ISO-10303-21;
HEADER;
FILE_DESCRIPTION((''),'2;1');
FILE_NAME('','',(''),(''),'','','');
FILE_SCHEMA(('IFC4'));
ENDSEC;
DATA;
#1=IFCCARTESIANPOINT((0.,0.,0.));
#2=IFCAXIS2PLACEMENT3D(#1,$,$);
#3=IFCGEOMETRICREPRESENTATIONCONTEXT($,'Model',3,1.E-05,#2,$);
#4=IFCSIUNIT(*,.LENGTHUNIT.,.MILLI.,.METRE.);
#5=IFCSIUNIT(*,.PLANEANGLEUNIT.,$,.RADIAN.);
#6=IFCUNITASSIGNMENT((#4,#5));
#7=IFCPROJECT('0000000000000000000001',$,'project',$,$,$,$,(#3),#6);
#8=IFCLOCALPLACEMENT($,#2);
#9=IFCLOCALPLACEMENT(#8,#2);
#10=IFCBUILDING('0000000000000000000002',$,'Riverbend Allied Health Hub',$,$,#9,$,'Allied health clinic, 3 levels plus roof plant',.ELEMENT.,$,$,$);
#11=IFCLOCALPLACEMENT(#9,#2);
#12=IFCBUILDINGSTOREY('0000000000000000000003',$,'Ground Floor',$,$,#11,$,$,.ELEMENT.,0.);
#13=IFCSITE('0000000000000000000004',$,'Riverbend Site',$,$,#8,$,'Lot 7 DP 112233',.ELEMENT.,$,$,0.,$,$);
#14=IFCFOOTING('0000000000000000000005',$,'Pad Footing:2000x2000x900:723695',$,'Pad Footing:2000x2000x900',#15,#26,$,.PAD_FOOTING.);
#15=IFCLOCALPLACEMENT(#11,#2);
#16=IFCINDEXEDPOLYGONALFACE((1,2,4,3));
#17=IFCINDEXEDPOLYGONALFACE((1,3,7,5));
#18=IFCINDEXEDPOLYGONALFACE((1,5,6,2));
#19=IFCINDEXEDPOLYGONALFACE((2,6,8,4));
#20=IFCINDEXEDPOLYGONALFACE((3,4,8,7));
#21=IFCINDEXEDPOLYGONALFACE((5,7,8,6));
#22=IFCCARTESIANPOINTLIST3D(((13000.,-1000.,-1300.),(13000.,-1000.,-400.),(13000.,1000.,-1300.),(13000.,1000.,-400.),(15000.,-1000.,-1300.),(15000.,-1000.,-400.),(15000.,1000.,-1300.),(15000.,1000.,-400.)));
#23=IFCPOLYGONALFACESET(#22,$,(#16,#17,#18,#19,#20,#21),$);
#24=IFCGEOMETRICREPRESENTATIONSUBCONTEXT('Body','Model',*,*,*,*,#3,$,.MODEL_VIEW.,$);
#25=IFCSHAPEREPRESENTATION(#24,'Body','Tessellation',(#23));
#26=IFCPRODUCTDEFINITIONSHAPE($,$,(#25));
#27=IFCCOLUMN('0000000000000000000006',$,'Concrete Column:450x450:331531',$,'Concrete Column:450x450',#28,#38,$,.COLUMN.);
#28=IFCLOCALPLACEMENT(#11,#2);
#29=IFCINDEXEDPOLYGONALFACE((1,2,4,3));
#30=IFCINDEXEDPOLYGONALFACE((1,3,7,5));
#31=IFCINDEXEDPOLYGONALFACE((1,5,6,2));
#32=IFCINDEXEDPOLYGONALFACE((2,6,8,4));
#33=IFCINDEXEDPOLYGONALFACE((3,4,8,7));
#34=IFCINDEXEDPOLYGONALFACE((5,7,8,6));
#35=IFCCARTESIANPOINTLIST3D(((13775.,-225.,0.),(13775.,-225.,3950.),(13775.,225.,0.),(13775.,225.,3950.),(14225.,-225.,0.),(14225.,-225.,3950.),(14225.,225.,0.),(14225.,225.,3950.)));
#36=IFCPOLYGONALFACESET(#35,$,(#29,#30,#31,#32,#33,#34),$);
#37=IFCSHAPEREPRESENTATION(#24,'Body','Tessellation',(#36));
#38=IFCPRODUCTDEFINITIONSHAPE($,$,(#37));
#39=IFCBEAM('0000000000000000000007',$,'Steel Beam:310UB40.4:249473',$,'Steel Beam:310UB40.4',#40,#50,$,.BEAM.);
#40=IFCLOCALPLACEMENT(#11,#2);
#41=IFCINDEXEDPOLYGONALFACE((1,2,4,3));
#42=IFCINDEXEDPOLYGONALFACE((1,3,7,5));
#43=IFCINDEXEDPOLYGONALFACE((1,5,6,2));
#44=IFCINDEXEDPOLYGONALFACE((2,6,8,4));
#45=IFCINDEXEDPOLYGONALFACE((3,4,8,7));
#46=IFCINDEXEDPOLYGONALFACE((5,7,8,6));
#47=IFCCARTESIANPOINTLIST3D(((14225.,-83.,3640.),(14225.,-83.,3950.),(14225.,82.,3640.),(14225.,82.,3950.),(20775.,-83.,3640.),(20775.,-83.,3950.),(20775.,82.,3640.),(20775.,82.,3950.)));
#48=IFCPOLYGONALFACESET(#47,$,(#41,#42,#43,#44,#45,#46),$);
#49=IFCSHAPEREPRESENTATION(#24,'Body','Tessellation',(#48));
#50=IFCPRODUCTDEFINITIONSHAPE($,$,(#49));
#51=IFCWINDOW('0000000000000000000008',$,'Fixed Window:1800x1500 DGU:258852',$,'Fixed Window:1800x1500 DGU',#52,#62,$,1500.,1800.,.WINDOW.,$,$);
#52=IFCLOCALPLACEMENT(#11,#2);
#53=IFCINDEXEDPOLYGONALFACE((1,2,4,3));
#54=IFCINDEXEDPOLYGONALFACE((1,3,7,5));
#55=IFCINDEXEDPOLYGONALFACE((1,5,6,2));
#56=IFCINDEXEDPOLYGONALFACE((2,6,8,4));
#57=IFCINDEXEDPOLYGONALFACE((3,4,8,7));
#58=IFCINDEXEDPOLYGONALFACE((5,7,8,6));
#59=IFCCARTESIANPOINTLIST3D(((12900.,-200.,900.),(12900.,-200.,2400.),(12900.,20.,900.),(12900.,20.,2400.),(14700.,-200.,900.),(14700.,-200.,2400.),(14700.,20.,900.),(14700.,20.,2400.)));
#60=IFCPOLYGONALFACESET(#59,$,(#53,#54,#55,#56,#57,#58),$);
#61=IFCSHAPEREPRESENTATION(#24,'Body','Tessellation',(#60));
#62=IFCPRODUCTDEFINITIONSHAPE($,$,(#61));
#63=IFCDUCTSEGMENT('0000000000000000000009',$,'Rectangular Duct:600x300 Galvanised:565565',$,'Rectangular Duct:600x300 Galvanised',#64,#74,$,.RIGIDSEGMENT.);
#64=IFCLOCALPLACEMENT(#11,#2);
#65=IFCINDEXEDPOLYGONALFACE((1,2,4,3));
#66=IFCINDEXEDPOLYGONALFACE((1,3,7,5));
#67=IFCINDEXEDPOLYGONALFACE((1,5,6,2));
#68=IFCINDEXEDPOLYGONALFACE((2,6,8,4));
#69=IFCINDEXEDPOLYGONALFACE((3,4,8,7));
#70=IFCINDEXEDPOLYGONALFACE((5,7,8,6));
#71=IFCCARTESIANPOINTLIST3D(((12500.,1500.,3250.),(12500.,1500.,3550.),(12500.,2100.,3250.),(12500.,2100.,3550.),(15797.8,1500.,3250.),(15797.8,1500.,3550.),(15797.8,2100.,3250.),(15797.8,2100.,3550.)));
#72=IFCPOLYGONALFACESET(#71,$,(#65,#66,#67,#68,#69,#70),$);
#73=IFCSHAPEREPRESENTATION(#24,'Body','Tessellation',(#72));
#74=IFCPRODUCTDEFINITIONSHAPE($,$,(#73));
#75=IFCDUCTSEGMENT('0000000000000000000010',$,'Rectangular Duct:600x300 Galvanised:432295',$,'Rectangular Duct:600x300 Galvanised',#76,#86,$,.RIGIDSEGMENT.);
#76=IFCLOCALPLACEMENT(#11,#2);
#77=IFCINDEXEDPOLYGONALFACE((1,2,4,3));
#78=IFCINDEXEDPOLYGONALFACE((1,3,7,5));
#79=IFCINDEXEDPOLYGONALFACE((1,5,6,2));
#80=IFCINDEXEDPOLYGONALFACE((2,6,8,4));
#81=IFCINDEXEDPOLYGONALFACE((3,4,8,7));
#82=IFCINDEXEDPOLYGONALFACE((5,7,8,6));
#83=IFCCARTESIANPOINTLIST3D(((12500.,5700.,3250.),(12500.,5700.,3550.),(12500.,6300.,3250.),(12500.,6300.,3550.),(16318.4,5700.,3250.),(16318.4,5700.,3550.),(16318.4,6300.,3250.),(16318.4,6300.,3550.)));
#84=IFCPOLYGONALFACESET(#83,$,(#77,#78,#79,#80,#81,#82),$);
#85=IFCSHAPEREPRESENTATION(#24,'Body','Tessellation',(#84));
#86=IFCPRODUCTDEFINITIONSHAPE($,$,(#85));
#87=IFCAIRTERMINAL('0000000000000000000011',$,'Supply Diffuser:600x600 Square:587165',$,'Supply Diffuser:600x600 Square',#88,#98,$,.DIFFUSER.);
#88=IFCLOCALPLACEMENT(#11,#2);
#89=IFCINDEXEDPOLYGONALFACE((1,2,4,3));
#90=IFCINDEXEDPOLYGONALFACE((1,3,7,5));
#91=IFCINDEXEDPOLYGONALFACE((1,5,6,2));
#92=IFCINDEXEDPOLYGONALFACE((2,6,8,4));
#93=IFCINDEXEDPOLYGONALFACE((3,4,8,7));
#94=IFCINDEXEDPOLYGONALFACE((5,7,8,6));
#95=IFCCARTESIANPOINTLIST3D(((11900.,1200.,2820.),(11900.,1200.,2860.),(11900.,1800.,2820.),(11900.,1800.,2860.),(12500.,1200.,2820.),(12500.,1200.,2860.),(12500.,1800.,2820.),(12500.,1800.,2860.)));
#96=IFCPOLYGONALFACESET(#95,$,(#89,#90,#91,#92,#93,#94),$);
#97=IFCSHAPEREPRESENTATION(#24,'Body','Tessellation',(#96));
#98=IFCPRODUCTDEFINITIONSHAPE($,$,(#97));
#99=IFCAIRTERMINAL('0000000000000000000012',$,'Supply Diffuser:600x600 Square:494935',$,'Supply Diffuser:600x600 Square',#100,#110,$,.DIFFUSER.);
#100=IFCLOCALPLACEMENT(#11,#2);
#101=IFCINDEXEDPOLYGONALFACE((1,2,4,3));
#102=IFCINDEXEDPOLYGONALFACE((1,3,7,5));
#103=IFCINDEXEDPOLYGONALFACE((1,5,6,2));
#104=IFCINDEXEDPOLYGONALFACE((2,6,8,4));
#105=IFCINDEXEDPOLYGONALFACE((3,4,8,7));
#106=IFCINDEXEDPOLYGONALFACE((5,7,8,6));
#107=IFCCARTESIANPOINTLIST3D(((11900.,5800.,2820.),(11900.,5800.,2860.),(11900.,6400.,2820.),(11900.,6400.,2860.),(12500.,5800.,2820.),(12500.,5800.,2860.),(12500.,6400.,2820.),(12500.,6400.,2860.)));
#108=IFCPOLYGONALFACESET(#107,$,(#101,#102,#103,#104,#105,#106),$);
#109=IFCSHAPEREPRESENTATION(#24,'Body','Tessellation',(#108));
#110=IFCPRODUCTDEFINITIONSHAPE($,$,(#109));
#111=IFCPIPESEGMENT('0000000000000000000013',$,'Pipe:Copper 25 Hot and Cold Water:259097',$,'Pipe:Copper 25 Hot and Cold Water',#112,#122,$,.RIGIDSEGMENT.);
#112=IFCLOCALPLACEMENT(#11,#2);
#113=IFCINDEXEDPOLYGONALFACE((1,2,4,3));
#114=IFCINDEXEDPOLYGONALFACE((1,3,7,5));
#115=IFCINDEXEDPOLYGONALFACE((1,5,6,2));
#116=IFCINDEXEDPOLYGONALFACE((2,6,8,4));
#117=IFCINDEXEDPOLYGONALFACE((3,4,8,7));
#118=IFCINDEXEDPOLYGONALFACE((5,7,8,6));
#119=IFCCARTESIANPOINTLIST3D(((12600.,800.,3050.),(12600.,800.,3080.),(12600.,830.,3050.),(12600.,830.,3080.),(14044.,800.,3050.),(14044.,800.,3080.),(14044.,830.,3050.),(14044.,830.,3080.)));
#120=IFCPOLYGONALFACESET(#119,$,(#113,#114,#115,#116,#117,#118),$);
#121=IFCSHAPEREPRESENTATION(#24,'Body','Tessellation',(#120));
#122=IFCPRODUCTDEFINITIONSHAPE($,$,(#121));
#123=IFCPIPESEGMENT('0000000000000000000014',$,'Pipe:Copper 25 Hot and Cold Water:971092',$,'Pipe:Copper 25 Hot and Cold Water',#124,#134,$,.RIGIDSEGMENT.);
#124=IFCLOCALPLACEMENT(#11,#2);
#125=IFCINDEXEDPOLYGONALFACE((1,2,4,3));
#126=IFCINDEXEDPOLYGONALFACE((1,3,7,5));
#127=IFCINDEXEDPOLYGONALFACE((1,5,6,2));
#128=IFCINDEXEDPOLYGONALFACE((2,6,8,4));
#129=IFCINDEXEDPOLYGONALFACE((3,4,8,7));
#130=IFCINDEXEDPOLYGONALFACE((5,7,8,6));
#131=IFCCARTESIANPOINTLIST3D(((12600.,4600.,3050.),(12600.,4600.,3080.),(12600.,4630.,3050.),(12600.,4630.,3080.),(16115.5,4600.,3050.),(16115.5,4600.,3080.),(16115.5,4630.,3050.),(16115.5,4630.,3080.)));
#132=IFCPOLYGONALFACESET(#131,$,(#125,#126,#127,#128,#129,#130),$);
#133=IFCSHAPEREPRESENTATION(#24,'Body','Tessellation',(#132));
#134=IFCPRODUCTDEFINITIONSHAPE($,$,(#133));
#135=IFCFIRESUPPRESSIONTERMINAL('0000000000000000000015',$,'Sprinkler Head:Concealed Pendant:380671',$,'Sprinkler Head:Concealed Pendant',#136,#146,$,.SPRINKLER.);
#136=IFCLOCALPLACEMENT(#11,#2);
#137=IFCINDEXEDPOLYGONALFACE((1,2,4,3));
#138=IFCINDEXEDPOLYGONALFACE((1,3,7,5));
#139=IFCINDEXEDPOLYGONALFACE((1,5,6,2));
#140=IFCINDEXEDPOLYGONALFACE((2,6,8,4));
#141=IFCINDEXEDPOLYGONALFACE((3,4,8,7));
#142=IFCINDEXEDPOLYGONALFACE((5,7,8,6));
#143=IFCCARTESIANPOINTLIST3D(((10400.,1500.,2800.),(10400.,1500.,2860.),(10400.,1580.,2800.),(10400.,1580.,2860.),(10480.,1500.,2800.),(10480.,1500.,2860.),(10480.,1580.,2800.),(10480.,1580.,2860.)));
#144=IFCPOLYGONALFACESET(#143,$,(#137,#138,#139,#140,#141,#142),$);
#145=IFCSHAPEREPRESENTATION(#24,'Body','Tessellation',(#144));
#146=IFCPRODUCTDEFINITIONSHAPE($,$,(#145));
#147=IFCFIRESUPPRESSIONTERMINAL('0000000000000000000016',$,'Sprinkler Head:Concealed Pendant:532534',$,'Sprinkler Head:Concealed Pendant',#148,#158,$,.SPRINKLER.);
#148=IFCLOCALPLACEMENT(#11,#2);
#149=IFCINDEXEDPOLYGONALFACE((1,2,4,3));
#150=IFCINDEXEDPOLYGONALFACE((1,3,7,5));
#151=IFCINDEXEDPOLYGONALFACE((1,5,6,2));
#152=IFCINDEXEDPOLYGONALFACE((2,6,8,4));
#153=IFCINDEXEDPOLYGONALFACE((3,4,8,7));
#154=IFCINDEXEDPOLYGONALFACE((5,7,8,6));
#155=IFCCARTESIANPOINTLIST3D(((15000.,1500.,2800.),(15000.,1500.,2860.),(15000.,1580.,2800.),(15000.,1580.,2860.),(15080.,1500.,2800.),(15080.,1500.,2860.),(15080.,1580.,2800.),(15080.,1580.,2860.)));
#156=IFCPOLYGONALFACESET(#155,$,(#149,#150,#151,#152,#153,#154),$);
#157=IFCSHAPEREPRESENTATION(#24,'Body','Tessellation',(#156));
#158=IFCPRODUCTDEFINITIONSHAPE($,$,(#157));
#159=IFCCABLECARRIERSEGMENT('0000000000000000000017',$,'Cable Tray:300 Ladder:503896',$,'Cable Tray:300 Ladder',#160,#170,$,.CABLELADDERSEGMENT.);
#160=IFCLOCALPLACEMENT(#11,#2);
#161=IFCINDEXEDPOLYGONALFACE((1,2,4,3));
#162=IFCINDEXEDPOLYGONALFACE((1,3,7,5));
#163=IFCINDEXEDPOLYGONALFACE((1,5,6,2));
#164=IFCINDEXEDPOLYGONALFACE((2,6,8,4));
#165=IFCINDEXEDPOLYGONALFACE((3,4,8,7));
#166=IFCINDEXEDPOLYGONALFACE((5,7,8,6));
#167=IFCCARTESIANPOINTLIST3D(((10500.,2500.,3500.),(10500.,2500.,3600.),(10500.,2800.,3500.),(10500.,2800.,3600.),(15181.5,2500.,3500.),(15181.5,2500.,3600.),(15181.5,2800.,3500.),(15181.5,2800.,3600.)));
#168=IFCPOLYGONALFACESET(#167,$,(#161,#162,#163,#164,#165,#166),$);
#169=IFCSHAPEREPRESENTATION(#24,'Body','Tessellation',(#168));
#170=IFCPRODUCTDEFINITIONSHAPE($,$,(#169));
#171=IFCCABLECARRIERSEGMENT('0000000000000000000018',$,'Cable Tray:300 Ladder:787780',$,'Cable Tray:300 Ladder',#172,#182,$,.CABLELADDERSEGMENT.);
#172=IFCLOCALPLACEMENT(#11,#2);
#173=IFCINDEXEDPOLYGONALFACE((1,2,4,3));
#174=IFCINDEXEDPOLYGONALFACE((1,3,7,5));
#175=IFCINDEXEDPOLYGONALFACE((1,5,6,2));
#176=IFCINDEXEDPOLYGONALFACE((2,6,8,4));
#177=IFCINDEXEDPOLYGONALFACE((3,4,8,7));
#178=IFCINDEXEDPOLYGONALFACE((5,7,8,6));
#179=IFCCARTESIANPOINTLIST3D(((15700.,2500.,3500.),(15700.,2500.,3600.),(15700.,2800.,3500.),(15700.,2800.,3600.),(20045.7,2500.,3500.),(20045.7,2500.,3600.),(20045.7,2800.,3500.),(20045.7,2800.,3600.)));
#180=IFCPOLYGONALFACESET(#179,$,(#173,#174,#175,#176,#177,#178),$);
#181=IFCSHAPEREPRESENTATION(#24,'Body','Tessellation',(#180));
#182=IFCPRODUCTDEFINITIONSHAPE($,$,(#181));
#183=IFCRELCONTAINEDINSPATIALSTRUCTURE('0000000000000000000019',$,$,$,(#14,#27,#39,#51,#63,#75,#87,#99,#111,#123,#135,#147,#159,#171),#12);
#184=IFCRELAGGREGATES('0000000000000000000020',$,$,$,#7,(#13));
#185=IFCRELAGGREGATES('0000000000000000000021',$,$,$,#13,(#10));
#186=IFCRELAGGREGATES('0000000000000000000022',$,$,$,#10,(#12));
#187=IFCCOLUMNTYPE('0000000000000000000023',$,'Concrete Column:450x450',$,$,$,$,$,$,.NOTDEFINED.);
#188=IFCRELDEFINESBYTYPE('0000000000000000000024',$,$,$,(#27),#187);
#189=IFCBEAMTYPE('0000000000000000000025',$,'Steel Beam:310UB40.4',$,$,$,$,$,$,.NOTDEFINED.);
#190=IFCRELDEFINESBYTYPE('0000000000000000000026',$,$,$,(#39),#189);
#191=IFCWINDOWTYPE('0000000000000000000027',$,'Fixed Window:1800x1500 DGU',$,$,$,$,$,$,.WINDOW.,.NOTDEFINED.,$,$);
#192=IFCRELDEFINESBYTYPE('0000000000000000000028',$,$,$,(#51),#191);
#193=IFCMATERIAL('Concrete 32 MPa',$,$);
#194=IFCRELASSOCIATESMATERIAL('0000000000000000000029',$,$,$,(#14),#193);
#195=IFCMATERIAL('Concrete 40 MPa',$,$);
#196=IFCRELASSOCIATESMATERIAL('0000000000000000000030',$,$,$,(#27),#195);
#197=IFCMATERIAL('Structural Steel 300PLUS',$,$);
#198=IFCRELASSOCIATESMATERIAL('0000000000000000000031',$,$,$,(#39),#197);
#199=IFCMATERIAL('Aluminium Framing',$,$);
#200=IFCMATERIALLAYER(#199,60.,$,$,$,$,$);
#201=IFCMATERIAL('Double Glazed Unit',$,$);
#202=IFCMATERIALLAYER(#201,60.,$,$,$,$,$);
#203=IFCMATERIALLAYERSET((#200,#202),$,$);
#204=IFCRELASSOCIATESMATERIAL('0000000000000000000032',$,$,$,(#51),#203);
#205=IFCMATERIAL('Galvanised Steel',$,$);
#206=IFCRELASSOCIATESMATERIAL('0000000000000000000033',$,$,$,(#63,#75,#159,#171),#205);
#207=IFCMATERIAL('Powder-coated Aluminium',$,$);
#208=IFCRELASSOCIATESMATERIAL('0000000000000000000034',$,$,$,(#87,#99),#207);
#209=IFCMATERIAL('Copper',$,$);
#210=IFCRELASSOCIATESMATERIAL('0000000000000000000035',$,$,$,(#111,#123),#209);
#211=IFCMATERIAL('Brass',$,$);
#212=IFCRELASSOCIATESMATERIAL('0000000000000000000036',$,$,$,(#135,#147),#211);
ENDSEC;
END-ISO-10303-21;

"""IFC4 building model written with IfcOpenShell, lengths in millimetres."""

from ifc_helpers import new_model, si_unit, frame, frame_2d, origin, place, context, subcontext, project, spatial, rectangle, extrude, material, layer, layer_set, layer_usage, type_object, element, save


model = new_model("IFC4")

# Units and contexts
model_context = context("Model", 3, precision=1e-05, world=origin())
body_context = subcontext(model_context, "Body", "Model", "MODEL_VIEW")
ifc_project = project(units=[si_unit("LENGTHUNIT", "METRE", prefix="MILLI"), si_unit("PLANEANGLEUNIT", "RADIAN")], contexts=[model_context])

# Site, building, storey
site_placement = place(None, origin())
site = spatial("IfcSite", under=ifc_project, at=site_placement, Name="Riverbend Site", LongName="Lot 7 DP 112233", CompositionType="ELEMENT", RefElevation=0.0)
building_placement = place(site_placement, origin())
building = spatial("IfcBuilding", under=site, at=building_placement, Name="Riverbend Allied Health Hub", LongName="Allied health clinic, 3 levels plus roof plant", CompositionType="ELEMENT")
storey_placement = place(building_placement, origin())
storey = spatial("IfcBuildingStorey", under=building, at=storey_placement, Name="Ground Floor", CompositionType="ELEMENT", Elevation=0.0)

# Footing
ifc_material_1 = material(Name="Concrete 32 MPa")
footing_placement = place(storey_placement, frame((13000.0, -1000.0, -1300.0)))
element("IfcFooting", 1, at=footing_placement, inside=storey, material=ifc_material_1, Name="Pad Footing:2000x2000x900:723695", ObjectType="Pad Footing:2000x2000x900", PredefinedType="PAD_FOOTING", context=body_context, shape_type="SweptSolid", body=[
    extrude(rectangle(XDim=2000.0, YDim=2000.0, at=frame_2d((1000.0, 1000.0))), origin(), (0.0, 0.0, 1.0), 900.0),
])

# Column
ifc_material_2 = material(Name="Concrete 40 MPa")
column_type = type_object("IfcColumnType", Name="Concrete Column:450x450", PredefinedType="NOTDEFINED")
column_placement = place(storey_placement, frame((13775.0, -225.0, 0.0)))
element("IfcColumn", 2, at=column_placement, inside=storey, type_object=column_type, material=ifc_material_2, Name="Concrete Column:450x450:331531", ObjectType="Concrete Column:450x450", PredefinedType="COLUMN", context=body_context, shape_type="SweptSolid", body=[
    extrude(rectangle(XDim=450.0, YDim=450.0, at=frame_2d((225.0, 225.0))), origin(), (0.0, 0.0, 1.0), 3950.0),
])

# Beam
ifc_material_3 = material(Name="Structural Steel 300PLUS")
beam_type = type_object("IfcBeamType", Name="Steel Beam:310UB40.4", PredefinedType="NOTDEFINED")
beam_placement = place(storey_placement, frame((14225.0, -83.0, 3640.0)))
element("IfcBeam", 3, at=beam_placement, inside=storey, type_object=beam_type, material=ifc_material_3, Name="Steel Beam:310UB40.4:249473", ObjectType="Steel Beam:310UB40.4", PredefinedType="BEAM", context=body_context, shape_type="SweptSolid", body=[
    extrude(rectangle(XDim=6550.0, YDim=165.0, at=frame_2d((3275.0, 82.5))), origin(), (0.0, 0.0, 1.0), 310.0),
])

# Window
ifc_material_4 = material(Name="Aluminium Framing")
ifc_layer_1 = layer(ifc_material_4, 60.0)
ifc_material_5 = material(Name="Double Glazed Unit")
ifc_layer_2 = layer(ifc_material_5, 60.0)
ifc_layer_set = layer_set([ifc_layer_1, ifc_layer_2])
ifc_layer_usage = layer_usage(ifc_layer_set, "AXIS2", "POSITIVE", 0.0)
window_type = type_object("IfcWindowType", Name="Fixed Window:1800x1500 DGU", PartitioningType="NOTDEFINED", PredefinedType="WINDOW")
window_placement = place(storey_placement, frame((12900.0, -200.0, 900.0)))
element("IfcWindow", 4, at=window_placement, inside=storey, type_object=window_type, material=ifc_layer_usage, Name="Fixed Window:1800x1500 DGU:258852", ObjectType="Fixed Window:1800x1500 DGU", OverallHeight=1500.0, OverallWidth=1800.0, PredefinedType="WINDOW", context=body_context, shape_type="SweptSolid", body=[
    extrude(rectangle(XDim=1800.0, YDim=220.0, at=frame_2d((900.0, 110.0))), origin(), (0.0, 0.0, 1.0), 1500.0),
])

# Duct segments
ifc_material_6 = material(Name="Galvanised Steel")
duct_segment_1_placement = place(storey_placement, frame((12500.0, 1500.0, 3250.0)))
element("IfcDuctSegment", 5, at=duct_segment_1_placement, inside=storey, material=ifc_material_6, Name="Rectangular Duct:600x300 Galvanised:565565", ObjectType="Rectangular Duct:600x300 Galvanised", PredefinedType="RIGIDSEGMENT", context=body_context, shape_type="SweptSolid", body=[
    extrude(rectangle(XDim=3297.8, YDim=600.0, at=frame_2d((1648.9, 300.0))), origin(), (0.0, 0.0, 1.0), 300.0),
])
duct_segment_2_placement = place(storey_placement, frame((12500.0, 5700.0, 3250.0)))
element("IfcDuctSegment", 6, at=duct_segment_2_placement, inside=storey, material=ifc_material_6, Name="Rectangular Duct:600x300 Galvanised:432295", ObjectType="Rectangular Duct:600x300 Galvanised", PredefinedType="RIGIDSEGMENT", context=body_context, shape_type="SweptSolid", body=[
    extrude(rectangle(XDim=3818.3, YDim=600.0, at=frame_2d((1909.2, 300.0))), origin(), (0.0, 0.0, 1.0), 300.0),
])

# Air terminals
ifc_material_7 = material(Name="Powder-coated Aluminium")
for number, where, name in (
    (7, (11900.0, 1200.0, 2820.0), "Supply Diffuser:600x600 Square:587165"),
    (8, (11900.0, 5800.0, 2820.0), "Supply Diffuser:600x600 Square:494935"),
):
    element("IfcAirTerminal", number, at=place(storey_placement, frame(where)), inside=storey, material=ifc_material_7, Name=name, ObjectType="Supply Diffuser:600x600 Square", PredefinedType="DIFFUSER", context=body_context, shape_type="SweptSolid", body=[
        extrude(rectangle(XDim=600.0, YDim=600.0, at=frame_2d((300.0, 300.0))), origin(), (0.0, 0.0, 1.0), 40.0),
    ])

# Pipe segments
ifc_material_8 = material(Name="Copper")
pipe_segment_1_placement = place(storey_placement, frame((12600.0, 800.0, 3050.0)))
element("IfcPipeSegment", 9, at=pipe_segment_1_placement, inside=storey, material=ifc_material_8, Name="Pipe:Copper 25 Hot and Cold Water:259097", ObjectType="Pipe:Copper 25 Hot and Cold Water", PredefinedType="RIGIDSEGMENT", context=body_context, shape_type="SweptSolid", body=[
    extrude(rectangle(XDim=1444.0, YDim=30.0, at=frame_2d((722.0, 15.0))), origin(), (0.0, 0.0, 1.0), 30.0),
])
pipe_segment_2_placement = place(storey_placement, frame((12600.0, 4600.0, 3050.0)))
element("IfcPipeSegment", 10, at=pipe_segment_2_placement, inside=storey, material=ifc_material_8, Name="Pipe:Copper 25 Hot and Cold Water:971092", ObjectType="Pipe:Copper 25 Hot and Cold Water", PredefinedType="RIGIDSEGMENT", context=body_context, shape_type="SweptSolid", body=[
    extrude(rectangle(XDim=3515.5, YDim=30.0, at=frame_2d((1757.7, 15.0))), origin(), (0.0, 0.0, 1.0), 30.0),
])

# Fire suppression terminals
ifc_material_9 = material(Name="Brass")
for number, where, name in (
    (11, (10400.0, 1500.0, 2800.0), "Sprinkler Head:Concealed Pendant:380671"),
    (12, (15000.0, 1500.0, 2800.0), "Sprinkler Head:Concealed Pendant:532534"),
):
    element("IfcFireSuppressionTerminal", number, at=place(storey_placement, frame(where)), inside=storey, material=ifc_material_9, Name=name, ObjectType="Sprinkler Head:Concealed Pendant", PredefinedType="SPRINKLER", context=body_context, shape_type="SweptSolid", body=[
        extrude(rectangle(XDim=80.0, YDim=80.0, at=frame_2d((40.0, 40.0))), origin(), (0.0, 0.0, 1.0), 60.0),
    ])

# Cable carrier segments
cable_carrier_segment_1_placement = place(storey_placement, frame((10500.0, 2500.0, 3500.0)))
element("IfcCableCarrierSegment", 13, at=cable_carrier_segment_1_placement, inside=storey, material=ifc_material_6, Name="Cable Tray:300 Ladder:503896", ObjectType="Cable Tray:300 Ladder", PredefinedType="CABLELADDERSEGMENT", context=body_context, shape_type="SweptSolid", body=[
    extrude(rectangle(XDim=4681.5, YDim=300.0, at=frame_2d((2340.7, 150.0))), origin(), (0.0, 0.0, 1.0), 100.0),
])
cable_carrier_segment_2_placement = place(storey_placement, frame((15700.0, 2500.0, 3500.0)))
element("IfcCableCarrierSegment", 14, at=cable_carrier_segment_2_placement, inside=storey, material=ifc_material_6, Name="Cable Tray:300 Ladder:787780", ObjectType="Cable Tray:300 Ladder", PredefinedType="CABLELADDERSEGMENT", context=body_context, shape_type="SweptSolid", body=[
    extrude(rectangle(XDim=4345.7, YDim=300.0, at=frame_2d((2172.8, 150.0))), origin(), (0.0, 0.0, 1.0), 100.0),
])

save(model, "model.ifc")
